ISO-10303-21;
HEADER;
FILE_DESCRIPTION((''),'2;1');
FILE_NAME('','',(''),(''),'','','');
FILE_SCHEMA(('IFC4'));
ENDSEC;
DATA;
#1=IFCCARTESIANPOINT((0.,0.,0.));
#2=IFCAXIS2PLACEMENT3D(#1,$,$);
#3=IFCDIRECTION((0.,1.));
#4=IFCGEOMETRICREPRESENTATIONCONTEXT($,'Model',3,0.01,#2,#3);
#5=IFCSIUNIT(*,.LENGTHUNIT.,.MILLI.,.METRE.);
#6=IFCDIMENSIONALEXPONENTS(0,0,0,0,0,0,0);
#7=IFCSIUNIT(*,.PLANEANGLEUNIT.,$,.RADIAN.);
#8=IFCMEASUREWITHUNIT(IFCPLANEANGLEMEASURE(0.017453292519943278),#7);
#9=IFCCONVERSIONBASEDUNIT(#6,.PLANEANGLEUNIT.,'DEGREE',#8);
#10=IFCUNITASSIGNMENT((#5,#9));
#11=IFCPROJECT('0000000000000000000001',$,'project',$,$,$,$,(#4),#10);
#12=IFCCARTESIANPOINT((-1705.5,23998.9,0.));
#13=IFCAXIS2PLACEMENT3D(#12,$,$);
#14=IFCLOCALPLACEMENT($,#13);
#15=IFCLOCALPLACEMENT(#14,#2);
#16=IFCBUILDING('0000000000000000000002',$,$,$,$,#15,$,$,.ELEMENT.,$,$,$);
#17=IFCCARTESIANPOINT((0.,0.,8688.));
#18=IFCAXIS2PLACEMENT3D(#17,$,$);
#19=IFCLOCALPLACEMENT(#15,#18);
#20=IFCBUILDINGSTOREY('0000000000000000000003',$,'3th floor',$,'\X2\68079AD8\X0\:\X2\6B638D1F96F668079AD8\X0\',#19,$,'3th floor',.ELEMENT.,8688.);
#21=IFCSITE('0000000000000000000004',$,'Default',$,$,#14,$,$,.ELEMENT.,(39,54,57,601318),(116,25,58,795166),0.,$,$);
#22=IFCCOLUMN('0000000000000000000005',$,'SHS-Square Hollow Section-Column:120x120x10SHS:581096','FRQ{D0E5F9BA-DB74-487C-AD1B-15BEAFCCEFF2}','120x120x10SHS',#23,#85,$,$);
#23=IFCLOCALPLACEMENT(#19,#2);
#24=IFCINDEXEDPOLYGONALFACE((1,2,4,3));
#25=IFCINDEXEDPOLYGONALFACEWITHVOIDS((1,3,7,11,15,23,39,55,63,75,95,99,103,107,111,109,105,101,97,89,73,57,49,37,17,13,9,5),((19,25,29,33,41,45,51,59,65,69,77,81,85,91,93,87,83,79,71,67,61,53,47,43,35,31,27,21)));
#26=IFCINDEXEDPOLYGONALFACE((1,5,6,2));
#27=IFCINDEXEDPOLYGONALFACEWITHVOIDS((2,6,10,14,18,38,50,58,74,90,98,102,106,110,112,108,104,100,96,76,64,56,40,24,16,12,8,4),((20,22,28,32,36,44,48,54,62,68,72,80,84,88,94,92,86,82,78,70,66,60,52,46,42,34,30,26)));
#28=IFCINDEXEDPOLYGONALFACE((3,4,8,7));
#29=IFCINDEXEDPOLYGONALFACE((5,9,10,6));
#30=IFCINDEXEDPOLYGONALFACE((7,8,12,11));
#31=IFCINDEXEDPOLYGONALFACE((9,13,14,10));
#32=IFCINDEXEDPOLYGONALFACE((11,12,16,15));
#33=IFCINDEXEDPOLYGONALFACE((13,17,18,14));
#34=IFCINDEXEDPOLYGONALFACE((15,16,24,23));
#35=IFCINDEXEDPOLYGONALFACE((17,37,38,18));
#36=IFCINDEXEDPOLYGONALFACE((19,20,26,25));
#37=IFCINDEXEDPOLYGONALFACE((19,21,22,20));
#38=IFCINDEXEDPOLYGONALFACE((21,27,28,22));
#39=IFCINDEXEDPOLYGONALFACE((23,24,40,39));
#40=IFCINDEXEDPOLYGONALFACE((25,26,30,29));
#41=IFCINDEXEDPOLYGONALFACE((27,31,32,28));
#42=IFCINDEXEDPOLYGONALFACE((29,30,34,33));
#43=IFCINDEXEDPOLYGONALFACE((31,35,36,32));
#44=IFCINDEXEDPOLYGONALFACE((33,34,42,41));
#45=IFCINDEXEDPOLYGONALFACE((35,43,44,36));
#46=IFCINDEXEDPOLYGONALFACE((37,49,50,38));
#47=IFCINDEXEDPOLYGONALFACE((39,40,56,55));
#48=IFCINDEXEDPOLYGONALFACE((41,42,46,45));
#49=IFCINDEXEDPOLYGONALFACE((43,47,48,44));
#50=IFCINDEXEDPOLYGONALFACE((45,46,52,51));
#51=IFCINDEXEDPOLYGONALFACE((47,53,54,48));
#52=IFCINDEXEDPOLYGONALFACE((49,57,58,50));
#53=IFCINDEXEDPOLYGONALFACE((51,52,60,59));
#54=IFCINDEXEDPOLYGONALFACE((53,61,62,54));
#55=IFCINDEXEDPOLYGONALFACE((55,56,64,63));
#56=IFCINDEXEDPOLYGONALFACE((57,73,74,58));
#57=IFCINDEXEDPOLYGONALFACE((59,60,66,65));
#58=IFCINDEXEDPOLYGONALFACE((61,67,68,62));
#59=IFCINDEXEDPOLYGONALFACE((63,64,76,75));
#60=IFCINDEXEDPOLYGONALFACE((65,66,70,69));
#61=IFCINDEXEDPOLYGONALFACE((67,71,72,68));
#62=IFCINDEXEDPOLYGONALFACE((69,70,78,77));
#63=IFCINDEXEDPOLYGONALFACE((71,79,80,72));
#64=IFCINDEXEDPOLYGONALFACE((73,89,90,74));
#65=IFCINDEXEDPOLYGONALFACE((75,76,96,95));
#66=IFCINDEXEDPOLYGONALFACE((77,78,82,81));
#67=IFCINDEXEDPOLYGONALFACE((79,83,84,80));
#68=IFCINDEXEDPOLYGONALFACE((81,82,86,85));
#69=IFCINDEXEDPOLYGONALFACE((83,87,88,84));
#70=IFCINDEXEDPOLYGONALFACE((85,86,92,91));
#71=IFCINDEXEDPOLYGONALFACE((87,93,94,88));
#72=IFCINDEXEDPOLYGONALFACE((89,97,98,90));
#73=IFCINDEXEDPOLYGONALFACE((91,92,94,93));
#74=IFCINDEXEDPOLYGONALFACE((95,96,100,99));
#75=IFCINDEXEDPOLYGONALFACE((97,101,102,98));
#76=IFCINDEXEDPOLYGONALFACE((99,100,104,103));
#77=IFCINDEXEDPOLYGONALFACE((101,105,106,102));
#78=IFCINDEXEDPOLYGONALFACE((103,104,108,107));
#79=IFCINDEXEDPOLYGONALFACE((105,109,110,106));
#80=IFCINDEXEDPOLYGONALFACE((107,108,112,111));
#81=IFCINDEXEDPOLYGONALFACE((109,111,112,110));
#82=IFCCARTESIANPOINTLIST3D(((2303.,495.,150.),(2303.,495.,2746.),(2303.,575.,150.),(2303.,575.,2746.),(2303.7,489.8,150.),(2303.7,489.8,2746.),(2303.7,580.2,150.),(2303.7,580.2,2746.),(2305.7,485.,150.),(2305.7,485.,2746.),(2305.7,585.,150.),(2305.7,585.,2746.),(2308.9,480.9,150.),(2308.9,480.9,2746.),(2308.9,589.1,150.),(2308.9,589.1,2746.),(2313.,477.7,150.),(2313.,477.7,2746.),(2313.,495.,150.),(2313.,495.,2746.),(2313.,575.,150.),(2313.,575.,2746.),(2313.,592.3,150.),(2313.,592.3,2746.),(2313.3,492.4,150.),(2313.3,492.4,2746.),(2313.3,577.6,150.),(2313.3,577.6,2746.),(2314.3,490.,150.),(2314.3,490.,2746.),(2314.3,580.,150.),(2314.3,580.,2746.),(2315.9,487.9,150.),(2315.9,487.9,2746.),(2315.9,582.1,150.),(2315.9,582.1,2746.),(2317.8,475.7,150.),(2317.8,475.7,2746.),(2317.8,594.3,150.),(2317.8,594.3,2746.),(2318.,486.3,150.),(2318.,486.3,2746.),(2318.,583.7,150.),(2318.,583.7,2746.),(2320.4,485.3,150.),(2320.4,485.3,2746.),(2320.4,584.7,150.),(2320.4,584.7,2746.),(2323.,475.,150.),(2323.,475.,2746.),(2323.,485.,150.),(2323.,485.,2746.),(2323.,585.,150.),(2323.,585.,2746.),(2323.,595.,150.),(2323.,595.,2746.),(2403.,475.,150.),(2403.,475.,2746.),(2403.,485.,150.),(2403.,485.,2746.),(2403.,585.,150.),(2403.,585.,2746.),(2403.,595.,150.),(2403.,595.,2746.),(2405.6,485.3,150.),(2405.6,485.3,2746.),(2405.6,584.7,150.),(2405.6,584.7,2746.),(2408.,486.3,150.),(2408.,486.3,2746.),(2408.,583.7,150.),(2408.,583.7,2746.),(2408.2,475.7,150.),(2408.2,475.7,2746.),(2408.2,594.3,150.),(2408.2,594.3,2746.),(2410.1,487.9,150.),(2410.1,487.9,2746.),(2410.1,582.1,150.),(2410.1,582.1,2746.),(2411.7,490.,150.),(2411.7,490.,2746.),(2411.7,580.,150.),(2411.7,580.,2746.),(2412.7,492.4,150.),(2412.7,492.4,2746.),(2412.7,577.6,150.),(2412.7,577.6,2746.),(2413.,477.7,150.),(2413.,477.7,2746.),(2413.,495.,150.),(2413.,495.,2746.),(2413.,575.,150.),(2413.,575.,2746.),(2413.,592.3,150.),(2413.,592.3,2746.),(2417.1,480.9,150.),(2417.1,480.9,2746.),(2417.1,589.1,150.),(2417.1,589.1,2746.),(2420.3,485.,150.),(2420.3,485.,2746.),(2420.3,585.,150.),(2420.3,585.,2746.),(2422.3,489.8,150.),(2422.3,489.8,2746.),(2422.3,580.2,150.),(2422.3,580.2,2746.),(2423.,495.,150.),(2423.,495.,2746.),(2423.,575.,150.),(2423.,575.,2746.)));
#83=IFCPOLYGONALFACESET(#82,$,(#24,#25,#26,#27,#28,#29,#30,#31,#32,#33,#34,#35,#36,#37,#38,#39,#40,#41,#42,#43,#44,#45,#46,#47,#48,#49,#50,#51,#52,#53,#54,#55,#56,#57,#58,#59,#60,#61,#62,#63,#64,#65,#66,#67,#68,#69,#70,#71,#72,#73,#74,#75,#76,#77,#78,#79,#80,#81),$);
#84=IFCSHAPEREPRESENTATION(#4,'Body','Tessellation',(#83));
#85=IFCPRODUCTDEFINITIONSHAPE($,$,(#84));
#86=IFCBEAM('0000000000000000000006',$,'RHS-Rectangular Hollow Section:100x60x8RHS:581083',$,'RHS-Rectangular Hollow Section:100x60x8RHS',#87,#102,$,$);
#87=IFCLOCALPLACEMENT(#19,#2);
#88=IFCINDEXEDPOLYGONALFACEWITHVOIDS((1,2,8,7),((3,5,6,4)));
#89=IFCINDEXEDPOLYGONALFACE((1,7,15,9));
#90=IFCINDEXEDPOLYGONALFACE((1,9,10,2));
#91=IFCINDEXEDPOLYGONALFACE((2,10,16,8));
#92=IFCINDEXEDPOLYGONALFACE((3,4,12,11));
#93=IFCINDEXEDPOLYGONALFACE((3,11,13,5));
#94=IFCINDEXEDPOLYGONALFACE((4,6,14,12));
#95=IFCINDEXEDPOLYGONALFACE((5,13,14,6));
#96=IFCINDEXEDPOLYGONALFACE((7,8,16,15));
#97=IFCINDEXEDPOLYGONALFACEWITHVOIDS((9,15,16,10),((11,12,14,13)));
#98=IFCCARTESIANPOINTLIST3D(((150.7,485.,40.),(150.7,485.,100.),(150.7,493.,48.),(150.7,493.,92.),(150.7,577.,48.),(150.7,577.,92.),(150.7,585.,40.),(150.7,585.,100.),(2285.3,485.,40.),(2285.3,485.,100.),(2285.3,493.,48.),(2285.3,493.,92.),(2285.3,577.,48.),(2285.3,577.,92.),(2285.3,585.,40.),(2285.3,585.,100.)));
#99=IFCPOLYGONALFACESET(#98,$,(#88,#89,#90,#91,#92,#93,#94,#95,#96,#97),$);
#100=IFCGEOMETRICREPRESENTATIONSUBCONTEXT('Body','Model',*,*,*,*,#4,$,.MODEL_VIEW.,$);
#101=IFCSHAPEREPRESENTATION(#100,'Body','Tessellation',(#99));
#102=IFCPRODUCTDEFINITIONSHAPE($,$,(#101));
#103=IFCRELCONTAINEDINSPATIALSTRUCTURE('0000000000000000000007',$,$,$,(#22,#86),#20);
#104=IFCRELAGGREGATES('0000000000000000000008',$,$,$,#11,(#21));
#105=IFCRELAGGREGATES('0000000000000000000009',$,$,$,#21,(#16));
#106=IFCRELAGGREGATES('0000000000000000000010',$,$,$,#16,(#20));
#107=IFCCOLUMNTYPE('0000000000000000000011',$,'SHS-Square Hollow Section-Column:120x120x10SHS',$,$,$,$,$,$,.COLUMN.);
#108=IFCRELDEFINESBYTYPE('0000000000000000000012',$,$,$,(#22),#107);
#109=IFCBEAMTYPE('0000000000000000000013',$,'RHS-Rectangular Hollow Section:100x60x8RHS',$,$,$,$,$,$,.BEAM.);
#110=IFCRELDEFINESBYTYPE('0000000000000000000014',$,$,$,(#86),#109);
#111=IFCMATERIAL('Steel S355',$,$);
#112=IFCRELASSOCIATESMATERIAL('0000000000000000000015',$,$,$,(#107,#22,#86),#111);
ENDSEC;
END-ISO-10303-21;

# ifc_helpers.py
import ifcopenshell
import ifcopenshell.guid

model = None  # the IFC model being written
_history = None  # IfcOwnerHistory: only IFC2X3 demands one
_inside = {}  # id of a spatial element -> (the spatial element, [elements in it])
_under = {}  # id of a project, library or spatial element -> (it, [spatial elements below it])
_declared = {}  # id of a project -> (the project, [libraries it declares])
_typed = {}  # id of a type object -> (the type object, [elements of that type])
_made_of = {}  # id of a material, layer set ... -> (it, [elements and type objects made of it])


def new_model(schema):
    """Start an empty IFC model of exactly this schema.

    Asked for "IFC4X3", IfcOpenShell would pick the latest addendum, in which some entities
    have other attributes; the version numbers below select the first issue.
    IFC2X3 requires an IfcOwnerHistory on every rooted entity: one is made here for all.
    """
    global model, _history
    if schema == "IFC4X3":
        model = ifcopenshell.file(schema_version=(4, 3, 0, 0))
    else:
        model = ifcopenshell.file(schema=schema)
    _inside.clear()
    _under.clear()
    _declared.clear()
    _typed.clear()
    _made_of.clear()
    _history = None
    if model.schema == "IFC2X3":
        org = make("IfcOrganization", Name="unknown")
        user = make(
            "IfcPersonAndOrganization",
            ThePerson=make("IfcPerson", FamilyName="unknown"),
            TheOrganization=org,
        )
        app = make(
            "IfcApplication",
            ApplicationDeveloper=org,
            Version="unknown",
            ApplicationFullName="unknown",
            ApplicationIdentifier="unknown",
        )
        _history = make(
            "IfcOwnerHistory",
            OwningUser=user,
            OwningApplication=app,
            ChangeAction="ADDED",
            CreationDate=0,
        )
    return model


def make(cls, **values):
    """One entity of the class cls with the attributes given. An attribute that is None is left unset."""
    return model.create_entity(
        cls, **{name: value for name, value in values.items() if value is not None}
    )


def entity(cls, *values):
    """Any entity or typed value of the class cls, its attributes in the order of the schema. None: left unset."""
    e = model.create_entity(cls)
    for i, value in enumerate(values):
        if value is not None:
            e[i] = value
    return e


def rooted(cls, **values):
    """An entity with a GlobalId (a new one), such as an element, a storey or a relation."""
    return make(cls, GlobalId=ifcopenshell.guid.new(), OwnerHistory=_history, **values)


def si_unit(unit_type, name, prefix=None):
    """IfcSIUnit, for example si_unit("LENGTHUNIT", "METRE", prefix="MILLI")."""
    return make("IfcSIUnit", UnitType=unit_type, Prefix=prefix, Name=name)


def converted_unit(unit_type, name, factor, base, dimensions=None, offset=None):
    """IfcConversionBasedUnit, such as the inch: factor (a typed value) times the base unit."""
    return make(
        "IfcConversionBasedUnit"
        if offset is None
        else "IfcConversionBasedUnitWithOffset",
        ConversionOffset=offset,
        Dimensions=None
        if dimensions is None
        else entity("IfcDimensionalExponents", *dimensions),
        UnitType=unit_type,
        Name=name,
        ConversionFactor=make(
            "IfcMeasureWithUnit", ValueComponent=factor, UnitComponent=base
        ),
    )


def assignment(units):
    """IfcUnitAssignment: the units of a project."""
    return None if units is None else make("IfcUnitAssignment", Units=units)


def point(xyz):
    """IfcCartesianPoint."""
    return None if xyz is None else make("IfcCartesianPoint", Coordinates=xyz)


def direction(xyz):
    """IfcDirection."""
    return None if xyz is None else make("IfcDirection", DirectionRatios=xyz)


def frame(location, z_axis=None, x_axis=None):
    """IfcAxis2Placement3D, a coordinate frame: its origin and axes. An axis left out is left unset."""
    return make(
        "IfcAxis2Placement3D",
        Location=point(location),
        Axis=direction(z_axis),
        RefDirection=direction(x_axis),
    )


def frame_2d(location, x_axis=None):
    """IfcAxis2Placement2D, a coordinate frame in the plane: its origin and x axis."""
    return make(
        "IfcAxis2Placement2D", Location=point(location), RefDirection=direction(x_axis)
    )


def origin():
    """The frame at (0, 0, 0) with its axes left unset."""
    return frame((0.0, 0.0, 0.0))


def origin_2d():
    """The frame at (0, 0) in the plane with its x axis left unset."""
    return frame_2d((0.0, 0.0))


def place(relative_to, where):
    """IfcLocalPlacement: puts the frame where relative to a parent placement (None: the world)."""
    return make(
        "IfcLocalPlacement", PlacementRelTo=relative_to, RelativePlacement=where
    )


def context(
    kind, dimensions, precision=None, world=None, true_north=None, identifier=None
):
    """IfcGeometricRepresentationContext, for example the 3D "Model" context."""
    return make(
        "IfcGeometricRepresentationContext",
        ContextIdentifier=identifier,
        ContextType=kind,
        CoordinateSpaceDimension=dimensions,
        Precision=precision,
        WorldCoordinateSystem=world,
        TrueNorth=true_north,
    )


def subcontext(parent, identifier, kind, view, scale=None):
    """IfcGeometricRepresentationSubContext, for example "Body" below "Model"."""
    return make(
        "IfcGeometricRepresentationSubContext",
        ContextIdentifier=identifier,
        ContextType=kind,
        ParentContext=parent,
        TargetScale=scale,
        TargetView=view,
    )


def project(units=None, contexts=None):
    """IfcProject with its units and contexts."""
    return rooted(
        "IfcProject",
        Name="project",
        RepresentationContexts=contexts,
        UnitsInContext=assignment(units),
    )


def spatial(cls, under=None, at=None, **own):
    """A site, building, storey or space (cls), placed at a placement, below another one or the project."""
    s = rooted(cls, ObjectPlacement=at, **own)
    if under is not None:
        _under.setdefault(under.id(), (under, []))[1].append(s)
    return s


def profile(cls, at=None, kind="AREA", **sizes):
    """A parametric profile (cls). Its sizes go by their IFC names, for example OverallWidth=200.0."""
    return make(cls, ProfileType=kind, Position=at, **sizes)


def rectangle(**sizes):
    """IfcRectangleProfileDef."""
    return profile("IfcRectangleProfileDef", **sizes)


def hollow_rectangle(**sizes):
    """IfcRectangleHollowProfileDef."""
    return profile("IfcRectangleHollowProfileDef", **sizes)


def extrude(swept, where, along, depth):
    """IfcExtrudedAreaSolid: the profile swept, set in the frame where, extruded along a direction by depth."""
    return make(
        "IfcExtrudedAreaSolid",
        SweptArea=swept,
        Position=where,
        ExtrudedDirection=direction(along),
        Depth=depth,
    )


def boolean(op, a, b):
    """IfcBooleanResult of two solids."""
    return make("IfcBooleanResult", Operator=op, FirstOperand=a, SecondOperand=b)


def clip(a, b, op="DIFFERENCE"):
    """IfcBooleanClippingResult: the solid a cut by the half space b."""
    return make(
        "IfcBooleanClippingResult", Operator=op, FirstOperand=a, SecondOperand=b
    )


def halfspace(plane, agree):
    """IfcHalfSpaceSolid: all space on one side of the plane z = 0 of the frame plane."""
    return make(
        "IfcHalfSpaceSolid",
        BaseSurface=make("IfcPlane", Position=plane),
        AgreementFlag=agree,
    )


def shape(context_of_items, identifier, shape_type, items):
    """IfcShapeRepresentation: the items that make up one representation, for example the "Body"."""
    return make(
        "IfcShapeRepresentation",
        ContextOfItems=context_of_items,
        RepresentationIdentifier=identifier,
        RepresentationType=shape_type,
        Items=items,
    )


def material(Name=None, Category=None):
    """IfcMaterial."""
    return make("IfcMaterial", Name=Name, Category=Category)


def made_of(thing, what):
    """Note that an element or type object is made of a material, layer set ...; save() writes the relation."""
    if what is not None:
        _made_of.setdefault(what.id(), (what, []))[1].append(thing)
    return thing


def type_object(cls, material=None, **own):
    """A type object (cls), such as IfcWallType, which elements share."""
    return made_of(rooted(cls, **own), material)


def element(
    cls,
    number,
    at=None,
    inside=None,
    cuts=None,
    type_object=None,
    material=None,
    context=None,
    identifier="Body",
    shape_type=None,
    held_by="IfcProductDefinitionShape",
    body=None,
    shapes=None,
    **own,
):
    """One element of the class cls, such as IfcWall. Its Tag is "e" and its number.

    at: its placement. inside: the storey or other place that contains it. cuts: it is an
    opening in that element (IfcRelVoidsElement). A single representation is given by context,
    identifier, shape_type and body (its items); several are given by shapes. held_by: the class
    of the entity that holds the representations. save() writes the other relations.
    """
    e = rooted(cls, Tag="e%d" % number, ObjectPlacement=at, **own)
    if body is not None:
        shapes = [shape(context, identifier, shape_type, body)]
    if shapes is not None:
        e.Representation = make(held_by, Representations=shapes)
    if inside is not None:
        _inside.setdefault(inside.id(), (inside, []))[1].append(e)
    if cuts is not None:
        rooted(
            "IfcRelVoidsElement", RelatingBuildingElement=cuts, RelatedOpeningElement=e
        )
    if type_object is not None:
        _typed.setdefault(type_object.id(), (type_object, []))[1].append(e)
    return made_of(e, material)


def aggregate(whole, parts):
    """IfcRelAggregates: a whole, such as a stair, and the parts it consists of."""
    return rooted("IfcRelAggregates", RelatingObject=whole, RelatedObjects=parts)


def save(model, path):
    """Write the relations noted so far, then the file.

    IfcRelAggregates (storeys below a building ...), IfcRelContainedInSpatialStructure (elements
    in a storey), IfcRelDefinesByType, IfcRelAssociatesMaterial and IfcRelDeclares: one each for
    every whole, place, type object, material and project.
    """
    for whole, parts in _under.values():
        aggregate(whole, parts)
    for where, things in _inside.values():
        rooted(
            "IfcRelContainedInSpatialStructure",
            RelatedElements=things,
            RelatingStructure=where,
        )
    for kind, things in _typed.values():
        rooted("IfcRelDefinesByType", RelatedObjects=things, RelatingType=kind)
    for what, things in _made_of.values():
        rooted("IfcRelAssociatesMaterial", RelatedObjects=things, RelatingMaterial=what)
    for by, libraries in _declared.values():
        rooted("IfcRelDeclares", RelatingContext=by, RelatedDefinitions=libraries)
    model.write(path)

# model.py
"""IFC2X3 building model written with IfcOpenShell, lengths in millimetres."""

from ifc_helpers import new_model, entity, si_unit, converted_unit, direction, frame, frame_2d, origin, origin_2d, place, context, subcontext, project, spatial, rectangle, hollow_rectangle, extrude, boolean, clip, halfspace, material, type_object, element, save


model = new_model("IFC2X3")

# Units and contexts
model_context = context("Model", 3, precision=0.01, world=origin(), true_north=direction((0.0, 1.0)))
body_context = subcontext(model_context, "Body", "Model", "MODEL_VIEW")
ifc_project = project(units=[si_unit("LENGTHUNIT", "METRE", prefix="MILLI"), converted_unit("PLANEANGLEUNIT", "DEGREE", entity("IfcPlaneAngleMeasure", 0.017453292519943278), si_unit("PLANEANGLEUNIT", "RADIAN"), dimensions=[0, 0, 0, 0, 0, 0, 0])], contexts=[model_context])

# Site, building, storey
site_placement = place(None, frame((-1705.5, 23998.9, 0.0)))
site = spatial("IfcSite", under=ifc_project, at=site_placement, Name="Default", CompositionType="ELEMENT", RefLatitude=(39, 54, 57, 601318), RefLongitude=(116, 25, 58, 795166), RefElevation=0.0)
building_placement = place(site_placement, origin())
building = spatial("IfcBuilding", under=site, at=building_placement, CompositionType="ELEMENT")
storey_placement = place(building_placement, frame((0.0, 0.0, 8688.0)))
storey = spatial("IfcBuildingStorey", under=building, at=storey_placement, Name="3th floor", ObjectType="标高:正负零标高", LongName="3th floor", CompositionType="ELEMENT", Elevation=8688.0)

# Column
ifc_material = material(Name="Steel S355")
column_type_1 = type_object("IfcColumnType", Name="SHS-Square Hollow Section-Column:120x120x10SHS", PredefinedType="COLUMN", material=ifc_material)
column_1_placement = place(storey_placement, frame((2363.0, 535.0, 2746.0), z_axis=(0.0, 0.0, 1.0), x_axis=(0.0, -1.0, 0.0)))
element("IfcColumn", 1, at=column_1_placement, inside=storey, type_object=column_type_1, material=ifc_material, Name="SHS-Square Hollow Section-Column:120x120x10SHS:581096", Description="FRQ{D0E5F9BA-DB74-487C-AD1B-15BEAFCCEFF2}", ObjectType="120x120x10SHS", context=model_context, shape_type="Clipping", body=[
    clip(extrude(hollow_rectangle(XDim=120.0, YDim=120.0, WallThickness=10.0, InnerFilletRadius=10.0, OuterFilletRadius=20.0, at=origin_2d()), origin(), (0.0, 0.0, -1.0), 2680.9), halfspace(frame((535.0, -2363.0, -2596.0), z_axis=(0.0, 0.0, 1.0), x_axis=(0.0, 1.0, 0.0)), True)),
])

# Beam
beam_type = type_object("IfcBeamType", Name="RHS-Rectangular Hollow Section:100x60x8RHS", PredefinedType="BEAM")
beam_placement = place(storey_placement, frame((150.7, 585.0, 70.0)))
element("IfcBeam", 2, at=beam_placement, inside=storey, type_object=beam_type, material=ifc_material, Name="RHS-Rectangular Hollow Section:100x60x8RHS:581083", ObjectType="RHS-Rectangular Hollow Section:100x60x8RHS", context=body_context, shape_type="SweptSolid", body=[
    boolean("DIFFERENCE", extrude(rectangle(XDim=60.0, YDim=100.0, at=frame_2d((0.0, 0.0), x_axis=(1.0, 0.0))), frame((0.0, -50.0, 0.0), z_axis=(1.0, 0.0, 0.0), x_axis=(0.0, 0.0, -1.0)), (0.0, 0.0, 1.0), 2134.6), extrude(rectangle(XDim=44.0, YDim=84.0, at=frame_2d((0.0, 0.0), x_axis=(0.0, 1.0))), frame((2134.6, -50.0, 0.0), z_axis=(-1.0, 0.0, 0.0), x_axis=(0.0, 1.0, 0.0)), (0.0, 0.0, 1.0), 2134.6)),
])

save(model, "model.ifc")
